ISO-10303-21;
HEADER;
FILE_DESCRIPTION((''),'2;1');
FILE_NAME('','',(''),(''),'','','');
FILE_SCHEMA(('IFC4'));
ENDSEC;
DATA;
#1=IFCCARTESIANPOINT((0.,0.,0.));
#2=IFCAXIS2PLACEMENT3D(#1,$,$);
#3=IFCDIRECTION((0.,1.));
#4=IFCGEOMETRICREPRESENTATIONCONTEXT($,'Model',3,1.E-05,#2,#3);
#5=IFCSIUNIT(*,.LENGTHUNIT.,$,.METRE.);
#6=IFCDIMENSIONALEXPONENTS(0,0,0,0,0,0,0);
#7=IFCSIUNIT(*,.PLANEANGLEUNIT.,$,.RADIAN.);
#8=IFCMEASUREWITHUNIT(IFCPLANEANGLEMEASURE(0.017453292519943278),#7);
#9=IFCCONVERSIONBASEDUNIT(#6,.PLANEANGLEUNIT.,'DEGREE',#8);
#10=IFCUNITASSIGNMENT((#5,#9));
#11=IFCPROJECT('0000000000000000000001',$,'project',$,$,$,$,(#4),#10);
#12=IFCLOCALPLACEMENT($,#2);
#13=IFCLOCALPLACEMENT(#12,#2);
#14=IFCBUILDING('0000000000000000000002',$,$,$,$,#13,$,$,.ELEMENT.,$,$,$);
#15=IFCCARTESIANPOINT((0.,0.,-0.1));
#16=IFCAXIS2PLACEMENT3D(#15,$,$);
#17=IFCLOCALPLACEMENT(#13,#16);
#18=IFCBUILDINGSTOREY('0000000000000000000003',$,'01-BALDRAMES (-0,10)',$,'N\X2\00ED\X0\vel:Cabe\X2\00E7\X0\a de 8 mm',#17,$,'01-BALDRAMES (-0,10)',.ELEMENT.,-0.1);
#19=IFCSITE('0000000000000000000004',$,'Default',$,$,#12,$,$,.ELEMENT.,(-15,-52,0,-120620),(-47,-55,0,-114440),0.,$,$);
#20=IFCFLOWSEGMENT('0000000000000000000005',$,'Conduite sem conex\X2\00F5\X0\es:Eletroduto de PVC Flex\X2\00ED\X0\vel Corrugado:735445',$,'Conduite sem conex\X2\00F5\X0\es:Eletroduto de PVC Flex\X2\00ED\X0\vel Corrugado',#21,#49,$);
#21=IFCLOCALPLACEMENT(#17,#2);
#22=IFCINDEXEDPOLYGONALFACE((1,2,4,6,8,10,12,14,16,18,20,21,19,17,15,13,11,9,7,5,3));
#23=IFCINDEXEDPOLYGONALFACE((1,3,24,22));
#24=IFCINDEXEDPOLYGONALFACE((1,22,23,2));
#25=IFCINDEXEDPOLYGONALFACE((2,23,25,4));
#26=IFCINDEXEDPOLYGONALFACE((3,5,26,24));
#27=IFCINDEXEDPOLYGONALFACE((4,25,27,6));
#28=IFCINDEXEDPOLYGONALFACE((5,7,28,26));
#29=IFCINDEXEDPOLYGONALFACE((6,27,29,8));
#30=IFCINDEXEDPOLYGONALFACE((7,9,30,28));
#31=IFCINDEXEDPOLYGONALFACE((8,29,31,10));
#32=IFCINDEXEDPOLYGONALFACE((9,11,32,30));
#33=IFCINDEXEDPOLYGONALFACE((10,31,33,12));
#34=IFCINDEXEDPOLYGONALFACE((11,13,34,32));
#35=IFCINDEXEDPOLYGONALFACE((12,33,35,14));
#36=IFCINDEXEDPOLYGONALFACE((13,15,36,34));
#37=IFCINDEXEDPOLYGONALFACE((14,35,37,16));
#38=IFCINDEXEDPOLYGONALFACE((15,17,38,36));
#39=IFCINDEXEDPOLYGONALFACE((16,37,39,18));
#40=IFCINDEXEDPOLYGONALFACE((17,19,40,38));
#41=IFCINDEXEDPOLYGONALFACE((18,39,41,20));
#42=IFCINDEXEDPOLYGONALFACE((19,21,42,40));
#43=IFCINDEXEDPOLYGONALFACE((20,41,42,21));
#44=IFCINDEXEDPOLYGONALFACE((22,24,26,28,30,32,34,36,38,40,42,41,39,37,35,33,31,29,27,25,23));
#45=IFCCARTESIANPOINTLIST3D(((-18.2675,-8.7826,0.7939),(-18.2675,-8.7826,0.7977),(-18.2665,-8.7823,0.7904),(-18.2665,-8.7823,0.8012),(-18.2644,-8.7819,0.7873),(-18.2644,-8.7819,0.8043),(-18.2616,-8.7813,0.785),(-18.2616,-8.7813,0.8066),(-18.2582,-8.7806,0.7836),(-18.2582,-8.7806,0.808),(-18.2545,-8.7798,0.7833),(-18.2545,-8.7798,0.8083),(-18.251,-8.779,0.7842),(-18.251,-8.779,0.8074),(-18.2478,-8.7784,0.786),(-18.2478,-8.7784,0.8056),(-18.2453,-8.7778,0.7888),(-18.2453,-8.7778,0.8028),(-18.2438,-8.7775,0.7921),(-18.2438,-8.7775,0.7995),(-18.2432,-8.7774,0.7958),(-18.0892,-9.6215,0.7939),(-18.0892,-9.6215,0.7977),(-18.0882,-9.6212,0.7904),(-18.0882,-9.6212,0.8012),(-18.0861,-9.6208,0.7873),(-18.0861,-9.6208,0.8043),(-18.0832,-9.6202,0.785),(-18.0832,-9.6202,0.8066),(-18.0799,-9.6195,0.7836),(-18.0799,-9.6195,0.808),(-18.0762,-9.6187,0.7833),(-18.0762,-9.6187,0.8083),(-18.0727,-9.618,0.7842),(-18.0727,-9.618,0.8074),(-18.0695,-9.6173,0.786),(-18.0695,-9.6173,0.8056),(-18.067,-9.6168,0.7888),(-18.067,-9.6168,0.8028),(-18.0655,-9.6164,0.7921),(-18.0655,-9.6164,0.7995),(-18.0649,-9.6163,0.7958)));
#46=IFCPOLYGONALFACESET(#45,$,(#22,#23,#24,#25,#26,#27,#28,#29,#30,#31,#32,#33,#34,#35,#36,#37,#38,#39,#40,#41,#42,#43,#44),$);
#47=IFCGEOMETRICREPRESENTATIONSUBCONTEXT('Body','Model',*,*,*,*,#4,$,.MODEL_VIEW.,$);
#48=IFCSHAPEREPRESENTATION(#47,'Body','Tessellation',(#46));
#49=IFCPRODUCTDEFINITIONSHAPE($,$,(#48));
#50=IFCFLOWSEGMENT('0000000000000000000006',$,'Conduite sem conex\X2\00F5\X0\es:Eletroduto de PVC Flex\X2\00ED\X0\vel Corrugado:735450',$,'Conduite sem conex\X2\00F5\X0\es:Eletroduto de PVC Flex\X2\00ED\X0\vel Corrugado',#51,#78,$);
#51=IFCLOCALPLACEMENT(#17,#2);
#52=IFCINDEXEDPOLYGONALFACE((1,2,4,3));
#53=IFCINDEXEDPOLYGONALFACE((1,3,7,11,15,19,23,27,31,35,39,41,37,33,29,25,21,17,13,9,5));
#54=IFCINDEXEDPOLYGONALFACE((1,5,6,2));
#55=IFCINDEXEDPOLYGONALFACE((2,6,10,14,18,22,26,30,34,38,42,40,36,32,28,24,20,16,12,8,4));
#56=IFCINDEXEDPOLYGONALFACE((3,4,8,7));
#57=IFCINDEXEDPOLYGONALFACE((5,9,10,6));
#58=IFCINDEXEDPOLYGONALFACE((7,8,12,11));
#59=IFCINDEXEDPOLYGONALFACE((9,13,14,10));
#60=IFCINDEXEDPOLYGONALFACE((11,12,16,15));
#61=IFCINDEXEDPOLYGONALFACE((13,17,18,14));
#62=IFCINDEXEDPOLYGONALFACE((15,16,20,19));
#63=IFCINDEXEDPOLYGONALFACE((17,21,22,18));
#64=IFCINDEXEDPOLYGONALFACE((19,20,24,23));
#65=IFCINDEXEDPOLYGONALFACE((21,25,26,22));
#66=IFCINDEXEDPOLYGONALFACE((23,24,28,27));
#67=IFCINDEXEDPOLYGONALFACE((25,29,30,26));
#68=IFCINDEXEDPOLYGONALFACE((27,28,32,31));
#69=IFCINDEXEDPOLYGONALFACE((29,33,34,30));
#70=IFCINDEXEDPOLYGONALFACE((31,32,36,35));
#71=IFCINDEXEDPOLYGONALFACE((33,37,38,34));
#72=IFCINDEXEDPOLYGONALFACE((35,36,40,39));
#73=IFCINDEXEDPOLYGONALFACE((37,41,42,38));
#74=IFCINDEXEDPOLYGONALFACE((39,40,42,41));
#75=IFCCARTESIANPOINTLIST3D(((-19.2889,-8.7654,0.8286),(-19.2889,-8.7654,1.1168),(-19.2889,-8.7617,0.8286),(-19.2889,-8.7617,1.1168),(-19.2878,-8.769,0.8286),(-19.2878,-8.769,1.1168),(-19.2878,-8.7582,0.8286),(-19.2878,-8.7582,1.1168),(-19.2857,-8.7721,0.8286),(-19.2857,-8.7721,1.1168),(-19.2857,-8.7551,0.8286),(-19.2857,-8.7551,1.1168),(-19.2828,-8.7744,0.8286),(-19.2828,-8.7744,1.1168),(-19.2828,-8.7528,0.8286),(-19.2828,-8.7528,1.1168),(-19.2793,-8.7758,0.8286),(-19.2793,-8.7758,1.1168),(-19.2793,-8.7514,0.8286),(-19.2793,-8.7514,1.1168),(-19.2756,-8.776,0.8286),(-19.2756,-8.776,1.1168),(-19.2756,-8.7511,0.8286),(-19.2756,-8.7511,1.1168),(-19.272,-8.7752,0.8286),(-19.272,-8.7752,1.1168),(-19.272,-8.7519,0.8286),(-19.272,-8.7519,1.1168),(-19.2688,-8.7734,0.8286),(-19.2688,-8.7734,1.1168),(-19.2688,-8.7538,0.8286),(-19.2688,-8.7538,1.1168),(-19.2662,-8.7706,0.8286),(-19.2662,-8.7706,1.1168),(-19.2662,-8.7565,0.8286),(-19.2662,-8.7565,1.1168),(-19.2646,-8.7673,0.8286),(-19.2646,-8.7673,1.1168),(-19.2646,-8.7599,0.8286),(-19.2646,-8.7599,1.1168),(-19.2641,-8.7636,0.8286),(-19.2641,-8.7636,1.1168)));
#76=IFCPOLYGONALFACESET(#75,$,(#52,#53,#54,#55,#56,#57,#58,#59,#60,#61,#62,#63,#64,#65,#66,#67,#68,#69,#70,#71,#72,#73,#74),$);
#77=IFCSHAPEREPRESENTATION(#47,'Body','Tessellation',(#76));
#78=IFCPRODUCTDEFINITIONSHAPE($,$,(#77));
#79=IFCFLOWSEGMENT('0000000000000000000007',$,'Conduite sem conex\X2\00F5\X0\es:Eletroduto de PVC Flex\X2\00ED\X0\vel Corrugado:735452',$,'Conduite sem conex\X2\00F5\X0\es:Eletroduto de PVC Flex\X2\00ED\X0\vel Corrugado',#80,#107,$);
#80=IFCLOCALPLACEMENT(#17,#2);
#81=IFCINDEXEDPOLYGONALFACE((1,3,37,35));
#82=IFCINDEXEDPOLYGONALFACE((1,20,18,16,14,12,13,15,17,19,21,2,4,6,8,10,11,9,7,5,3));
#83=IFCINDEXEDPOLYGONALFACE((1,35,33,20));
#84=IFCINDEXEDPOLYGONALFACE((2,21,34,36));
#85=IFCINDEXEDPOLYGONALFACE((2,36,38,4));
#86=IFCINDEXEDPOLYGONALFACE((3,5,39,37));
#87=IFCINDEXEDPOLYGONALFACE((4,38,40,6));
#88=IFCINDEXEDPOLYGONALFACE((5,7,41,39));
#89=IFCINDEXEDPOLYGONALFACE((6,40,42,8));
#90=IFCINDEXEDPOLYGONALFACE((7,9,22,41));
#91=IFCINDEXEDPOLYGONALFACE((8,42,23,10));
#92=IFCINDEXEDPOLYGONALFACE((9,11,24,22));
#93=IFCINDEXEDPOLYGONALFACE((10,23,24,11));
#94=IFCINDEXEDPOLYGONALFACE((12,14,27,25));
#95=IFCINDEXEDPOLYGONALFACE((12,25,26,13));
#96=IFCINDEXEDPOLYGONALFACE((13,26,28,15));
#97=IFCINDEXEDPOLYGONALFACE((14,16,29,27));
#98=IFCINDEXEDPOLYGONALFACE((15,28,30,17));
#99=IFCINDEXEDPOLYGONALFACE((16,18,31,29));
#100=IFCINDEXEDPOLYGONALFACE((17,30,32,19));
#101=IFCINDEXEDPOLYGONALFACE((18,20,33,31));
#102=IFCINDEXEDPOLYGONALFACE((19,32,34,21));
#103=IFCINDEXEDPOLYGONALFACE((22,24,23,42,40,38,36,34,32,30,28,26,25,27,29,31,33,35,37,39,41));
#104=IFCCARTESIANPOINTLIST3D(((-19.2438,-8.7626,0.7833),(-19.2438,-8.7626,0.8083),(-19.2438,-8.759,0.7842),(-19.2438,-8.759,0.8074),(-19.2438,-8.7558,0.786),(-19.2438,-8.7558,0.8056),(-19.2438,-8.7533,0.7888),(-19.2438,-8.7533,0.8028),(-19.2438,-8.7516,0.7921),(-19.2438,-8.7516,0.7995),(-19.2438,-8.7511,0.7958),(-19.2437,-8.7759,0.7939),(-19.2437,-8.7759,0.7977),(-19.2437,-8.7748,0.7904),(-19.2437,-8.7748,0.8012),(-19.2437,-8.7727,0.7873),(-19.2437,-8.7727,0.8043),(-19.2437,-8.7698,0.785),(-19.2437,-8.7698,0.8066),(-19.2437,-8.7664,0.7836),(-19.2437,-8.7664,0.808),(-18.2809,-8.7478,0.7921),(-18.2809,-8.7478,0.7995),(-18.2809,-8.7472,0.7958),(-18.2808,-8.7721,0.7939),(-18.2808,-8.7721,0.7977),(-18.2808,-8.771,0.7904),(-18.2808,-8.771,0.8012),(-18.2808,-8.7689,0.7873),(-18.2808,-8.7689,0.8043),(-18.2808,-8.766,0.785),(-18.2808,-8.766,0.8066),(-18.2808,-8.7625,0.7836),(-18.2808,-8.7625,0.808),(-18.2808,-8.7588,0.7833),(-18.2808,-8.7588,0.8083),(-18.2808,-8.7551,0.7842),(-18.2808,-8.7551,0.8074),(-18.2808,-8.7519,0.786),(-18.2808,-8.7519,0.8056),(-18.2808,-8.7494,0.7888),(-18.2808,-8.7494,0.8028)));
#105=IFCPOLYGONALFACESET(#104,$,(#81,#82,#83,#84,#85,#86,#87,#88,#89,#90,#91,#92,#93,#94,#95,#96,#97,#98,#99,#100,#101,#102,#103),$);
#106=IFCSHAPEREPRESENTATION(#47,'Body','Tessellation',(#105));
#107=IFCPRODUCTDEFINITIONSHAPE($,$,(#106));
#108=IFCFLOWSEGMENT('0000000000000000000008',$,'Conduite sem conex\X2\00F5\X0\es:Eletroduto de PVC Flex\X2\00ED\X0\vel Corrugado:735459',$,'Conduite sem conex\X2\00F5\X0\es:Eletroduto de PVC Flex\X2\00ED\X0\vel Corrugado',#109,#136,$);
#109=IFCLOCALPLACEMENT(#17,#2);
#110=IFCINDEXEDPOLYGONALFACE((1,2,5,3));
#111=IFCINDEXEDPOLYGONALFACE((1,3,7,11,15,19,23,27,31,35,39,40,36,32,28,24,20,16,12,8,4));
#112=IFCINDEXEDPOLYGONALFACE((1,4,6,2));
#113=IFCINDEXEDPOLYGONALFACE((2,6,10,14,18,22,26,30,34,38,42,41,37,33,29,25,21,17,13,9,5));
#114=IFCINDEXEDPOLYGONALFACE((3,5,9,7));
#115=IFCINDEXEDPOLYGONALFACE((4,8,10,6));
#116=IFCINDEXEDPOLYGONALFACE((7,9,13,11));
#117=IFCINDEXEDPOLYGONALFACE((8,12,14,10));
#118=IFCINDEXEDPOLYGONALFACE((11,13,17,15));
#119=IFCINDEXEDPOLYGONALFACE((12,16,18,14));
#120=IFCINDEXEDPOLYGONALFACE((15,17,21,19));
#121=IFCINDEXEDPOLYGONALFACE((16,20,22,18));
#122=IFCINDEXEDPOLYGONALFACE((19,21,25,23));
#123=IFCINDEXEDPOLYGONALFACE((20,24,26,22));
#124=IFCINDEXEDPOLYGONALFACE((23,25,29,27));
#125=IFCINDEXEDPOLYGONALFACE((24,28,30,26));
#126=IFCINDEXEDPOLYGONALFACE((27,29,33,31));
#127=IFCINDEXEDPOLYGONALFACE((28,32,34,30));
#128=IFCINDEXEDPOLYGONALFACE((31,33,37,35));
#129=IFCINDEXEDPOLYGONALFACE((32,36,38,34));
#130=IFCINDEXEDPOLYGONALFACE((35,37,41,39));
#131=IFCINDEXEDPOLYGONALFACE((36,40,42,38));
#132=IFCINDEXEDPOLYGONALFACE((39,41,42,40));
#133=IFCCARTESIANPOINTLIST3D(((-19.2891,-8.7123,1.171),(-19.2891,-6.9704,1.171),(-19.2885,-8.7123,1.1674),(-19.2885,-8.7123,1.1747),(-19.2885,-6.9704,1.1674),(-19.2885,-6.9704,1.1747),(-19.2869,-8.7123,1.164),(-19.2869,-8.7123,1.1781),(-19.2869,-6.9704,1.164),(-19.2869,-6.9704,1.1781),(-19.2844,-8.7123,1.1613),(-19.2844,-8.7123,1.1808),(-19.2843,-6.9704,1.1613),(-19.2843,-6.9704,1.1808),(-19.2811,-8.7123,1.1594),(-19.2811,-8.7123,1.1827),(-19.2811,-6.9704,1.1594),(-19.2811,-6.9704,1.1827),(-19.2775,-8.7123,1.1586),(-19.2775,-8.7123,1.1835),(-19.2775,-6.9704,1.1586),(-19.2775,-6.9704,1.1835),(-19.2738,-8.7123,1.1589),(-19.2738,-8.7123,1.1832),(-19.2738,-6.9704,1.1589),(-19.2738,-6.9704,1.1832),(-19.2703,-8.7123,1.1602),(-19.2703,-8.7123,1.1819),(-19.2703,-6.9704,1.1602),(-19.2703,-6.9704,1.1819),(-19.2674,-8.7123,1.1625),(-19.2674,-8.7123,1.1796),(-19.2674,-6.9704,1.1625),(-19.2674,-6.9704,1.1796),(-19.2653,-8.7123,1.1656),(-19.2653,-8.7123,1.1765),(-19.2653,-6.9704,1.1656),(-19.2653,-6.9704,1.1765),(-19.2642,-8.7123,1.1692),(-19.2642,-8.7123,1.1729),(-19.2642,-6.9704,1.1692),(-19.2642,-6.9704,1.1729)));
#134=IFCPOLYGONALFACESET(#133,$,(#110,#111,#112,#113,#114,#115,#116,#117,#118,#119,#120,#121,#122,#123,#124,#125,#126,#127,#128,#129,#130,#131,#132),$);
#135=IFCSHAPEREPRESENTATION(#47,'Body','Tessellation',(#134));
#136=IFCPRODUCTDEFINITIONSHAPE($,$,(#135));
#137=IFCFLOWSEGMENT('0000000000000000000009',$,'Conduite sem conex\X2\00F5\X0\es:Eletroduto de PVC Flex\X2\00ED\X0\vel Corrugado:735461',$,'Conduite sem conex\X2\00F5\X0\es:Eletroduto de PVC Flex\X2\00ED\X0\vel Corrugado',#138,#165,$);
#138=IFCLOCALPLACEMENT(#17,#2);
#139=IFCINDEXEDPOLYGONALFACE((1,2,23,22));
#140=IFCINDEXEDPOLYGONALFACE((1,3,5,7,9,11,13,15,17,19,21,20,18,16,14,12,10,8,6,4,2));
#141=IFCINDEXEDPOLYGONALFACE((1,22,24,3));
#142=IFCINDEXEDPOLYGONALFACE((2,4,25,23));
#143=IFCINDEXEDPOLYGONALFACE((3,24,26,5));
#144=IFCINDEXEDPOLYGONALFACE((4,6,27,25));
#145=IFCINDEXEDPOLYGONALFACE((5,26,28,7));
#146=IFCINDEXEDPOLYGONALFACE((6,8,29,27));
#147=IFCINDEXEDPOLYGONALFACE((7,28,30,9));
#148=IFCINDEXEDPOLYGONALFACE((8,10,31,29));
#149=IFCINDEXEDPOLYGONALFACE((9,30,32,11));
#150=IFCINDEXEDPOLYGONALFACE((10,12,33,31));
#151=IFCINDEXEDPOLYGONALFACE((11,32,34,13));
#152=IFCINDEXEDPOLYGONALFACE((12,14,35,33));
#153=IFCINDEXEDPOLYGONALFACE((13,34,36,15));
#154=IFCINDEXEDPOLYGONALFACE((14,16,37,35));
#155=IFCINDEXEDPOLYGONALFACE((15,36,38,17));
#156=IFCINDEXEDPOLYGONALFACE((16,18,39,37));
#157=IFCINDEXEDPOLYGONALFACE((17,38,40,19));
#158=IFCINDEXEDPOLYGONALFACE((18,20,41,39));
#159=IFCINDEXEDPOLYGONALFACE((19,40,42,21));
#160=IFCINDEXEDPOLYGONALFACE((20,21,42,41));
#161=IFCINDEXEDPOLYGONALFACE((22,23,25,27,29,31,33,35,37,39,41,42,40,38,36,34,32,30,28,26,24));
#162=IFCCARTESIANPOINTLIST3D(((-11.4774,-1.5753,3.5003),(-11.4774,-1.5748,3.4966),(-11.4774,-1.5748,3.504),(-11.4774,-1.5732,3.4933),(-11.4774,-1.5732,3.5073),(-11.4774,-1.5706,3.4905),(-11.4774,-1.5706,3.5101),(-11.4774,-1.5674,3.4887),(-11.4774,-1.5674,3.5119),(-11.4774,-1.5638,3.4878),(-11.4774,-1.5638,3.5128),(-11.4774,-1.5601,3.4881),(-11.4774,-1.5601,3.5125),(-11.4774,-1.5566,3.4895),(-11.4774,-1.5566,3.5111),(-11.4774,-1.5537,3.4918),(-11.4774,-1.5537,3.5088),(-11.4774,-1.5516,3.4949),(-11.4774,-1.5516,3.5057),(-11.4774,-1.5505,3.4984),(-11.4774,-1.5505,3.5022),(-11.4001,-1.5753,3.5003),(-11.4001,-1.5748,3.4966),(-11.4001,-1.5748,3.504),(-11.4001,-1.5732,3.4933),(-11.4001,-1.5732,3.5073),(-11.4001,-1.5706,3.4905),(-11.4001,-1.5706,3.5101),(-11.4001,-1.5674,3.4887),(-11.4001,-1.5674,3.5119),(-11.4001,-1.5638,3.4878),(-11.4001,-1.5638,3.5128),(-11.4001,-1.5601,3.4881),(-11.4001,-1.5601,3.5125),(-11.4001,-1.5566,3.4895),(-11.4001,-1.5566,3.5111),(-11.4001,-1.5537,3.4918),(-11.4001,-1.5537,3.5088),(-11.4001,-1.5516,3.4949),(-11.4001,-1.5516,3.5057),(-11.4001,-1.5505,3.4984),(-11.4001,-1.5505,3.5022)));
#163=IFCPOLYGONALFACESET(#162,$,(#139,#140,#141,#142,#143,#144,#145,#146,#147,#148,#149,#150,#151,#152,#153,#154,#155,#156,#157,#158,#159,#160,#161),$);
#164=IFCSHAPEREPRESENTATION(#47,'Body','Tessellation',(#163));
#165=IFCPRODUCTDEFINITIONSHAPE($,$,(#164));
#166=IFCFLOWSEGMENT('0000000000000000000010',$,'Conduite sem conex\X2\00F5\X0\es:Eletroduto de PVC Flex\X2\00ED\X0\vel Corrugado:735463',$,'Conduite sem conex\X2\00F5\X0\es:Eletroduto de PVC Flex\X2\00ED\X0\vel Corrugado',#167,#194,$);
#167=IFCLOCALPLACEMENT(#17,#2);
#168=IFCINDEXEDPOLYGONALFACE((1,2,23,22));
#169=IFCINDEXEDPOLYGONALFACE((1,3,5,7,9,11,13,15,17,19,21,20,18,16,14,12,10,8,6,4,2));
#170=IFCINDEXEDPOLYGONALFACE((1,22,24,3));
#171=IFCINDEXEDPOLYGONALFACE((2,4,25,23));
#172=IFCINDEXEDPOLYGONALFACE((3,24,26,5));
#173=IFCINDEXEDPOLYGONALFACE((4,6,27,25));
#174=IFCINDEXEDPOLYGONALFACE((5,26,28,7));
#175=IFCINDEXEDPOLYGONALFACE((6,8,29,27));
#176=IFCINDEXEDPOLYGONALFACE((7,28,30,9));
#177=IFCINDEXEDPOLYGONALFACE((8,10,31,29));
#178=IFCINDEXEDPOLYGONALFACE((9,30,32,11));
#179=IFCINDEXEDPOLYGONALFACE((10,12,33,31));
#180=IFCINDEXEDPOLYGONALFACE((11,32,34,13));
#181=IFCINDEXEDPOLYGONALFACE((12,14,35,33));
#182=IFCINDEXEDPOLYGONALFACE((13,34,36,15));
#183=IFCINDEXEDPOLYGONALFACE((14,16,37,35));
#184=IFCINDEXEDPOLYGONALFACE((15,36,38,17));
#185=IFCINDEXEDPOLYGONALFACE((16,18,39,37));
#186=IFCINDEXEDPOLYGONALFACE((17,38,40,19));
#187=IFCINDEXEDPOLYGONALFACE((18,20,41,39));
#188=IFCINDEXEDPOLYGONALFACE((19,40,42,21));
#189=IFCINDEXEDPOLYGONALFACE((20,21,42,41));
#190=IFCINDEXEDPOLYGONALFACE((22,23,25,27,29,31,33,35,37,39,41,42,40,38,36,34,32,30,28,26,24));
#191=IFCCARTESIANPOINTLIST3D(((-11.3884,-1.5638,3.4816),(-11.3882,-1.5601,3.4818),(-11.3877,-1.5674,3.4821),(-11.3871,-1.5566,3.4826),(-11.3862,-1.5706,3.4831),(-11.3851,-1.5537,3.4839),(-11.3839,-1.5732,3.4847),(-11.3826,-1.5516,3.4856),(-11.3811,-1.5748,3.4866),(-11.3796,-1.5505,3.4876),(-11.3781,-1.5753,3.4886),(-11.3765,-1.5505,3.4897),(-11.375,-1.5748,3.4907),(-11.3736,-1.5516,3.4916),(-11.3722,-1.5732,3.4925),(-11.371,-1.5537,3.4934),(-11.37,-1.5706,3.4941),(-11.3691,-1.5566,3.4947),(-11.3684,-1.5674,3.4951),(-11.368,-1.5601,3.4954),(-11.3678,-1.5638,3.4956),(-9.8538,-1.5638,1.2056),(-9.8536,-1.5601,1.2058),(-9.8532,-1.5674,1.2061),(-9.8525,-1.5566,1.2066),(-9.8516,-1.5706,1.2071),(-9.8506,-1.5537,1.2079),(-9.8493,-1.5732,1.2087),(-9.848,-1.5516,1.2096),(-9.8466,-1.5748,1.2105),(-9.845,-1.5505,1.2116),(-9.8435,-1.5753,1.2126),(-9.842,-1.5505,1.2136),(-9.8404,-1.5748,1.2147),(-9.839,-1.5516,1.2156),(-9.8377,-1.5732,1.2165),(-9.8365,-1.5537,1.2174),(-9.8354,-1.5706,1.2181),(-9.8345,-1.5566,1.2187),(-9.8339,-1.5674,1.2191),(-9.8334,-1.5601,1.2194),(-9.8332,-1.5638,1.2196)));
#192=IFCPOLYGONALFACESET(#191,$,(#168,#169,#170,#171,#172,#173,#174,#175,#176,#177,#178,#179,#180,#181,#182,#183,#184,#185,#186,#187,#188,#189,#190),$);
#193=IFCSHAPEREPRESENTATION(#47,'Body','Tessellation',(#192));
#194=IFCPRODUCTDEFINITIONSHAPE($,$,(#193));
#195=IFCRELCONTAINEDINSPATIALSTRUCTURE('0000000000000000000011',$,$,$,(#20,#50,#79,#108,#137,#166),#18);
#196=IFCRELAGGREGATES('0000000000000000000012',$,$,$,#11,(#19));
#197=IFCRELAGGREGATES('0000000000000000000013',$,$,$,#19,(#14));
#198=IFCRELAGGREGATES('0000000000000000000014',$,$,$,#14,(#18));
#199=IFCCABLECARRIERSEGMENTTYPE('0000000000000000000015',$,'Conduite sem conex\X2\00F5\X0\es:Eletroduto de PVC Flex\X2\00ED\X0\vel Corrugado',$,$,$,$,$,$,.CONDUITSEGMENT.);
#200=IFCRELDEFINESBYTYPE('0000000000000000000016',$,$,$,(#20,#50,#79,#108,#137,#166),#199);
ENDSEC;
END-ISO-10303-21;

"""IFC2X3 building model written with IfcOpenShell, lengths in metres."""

from ifc_helpers import new_model, entity, si_unit, converted_unit, direction, frame, frame_2d, origin, origin_2d_with_axis, place, context, subcontext, project, spatial, circle, extrude, type_object, element, save


model = new_model("IFC2X3")

# Units and contexts
model_context = context("Model", 3, precision=1e-05, world=origin(), true_north=direction((0.0, 1.0)))
body_context = subcontext(model_context, "Body", "Model", "MODEL_VIEW")
ifc_project = project(units=[si_unit("LENGTHUNIT", "METRE"), converted_unit("PLANEANGLEUNIT", "DEGREE", entity("IfcPlaneAngleMeasure", 0.017453292519943278), si_unit("PLANEANGLEUNIT", "RADIAN"), dimensions=[0, 0, 0, 0, 0, 0, 0])], contexts=[model_context])

# Site, building, storey
site_placement = place(None, origin())
site = spatial("IfcSite", under=ifc_project, at=site_placement, Name="Default", CompositionType="ELEMENT", RefLatitude=(-15, -52, 0, -120620), RefLongitude=(-47, -55, 0, -114440), RefElevation=0.0)
building_placement = place(site_placement, origin())
building = spatial("IfcBuilding", under=site, at=building_placement, CompositionType="ELEMENT")
storey_placement = place(building_placement, frame((0.0, 0.0, -0.1)))
storey = spatial("IfcBuildingStorey", under=building, at=storey_placement, Name="01-BALDRAMES (-0,10)", ObjectType="Nível:Cabeça de 8 mm", LongName="01-BALDRAMES (-0,10)", CompositionType="ELEMENT", Elevation=-0.1)

# Flow segments
cable_carrier_segment_type = type_object("IfcCableCarrierSegmentType", Name="Conduite sem conexões:Eletroduto de PVC Flexível Corrugado", PredefinedType="CONDUITSEGMENT")
flow_segment_1_placement = place(storey_placement, origin())
element("IfcFlowSegment", 1, at=flow_segment_1_placement, inside=storey, type_object=cable_carrier_segment_type, Name="Conduite sem conexões:Eletroduto de PVC Flexível Corrugado:735445", ObjectType="Conduite sem conexões:Eletroduto de PVC Flexível Corrugado", context=body_context, shape_type="SweptSolid", body=[
    extrude(circle(Radius=0.0125, at=frame_2d((0.0, 0.0), x_axis=(1.0, 0.0))), frame((-18.2555, -8.78, 0.7958), z_axis=(0.207912, -0.978148, 0.0), x_axis=(0.978148, 0.207912, 0.0)), (0.0, 0.0, 1.0), 0.8577),
])
flow_segment_2_placement = place(storey_placement, origin())
element("IfcFlowSegment", 2, at=flow_segment_2_placement, inside=storey, type_object=cable_carrier_segment_type, Name="Conduite sem conexões:Eletroduto de PVC Flexível Corrugado:735450", ObjectType="Conduite sem conexões:Eletroduto de PVC Flexível Corrugado", context=body_context, shape_type="SweptSolid", body=[
    extrude(circle(Radius=0.0125, at=frame_2d((0.0, 0.0), x_axis=(1.0, 0.0))), frame((-19.2766, -8.7636, 0.8286)), (0.0, 0.0, 1.0), 0.2882),
])
flow_segment_3_placement = place(storey_placement, origin())
element("IfcFlowSegment", 3, at=flow_segment_3_placement, inside=storey, type_object=cable_carrier_segment_type, Name="Conduite sem conexões:Eletroduto de PVC Flexível Corrugado:735452", ObjectType="Conduite sem conexões:Eletroduto de PVC Flexível Corrugado", context=body_context, shape_type="SweptSolid", body=[
    extrude(circle(Radius=0.0125, at=origin_2d_with_axis()), frame((-19.2438, -8.7636, 0.7958), z_axis=(0.999992, 0.004026, 0.0), x_axis=(-0.004026, 0.999992, 0.0)), (0.0, 0.0, 1.0), 0.963),
])
flow_segment_4_placement = place(storey_placement, origin())
element("IfcFlowSegment", 4, at=flow_segment_4_placement, inside=storey, type_object=cable_carrier_segment_type, Name="Conduite sem conexões:Eletroduto de PVC Flexível Corrugado:735459", ObjectType="Conduite sem conexões:Eletroduto de PVC Flexível Corrugado", context=body_context, shape_type="SweptSolid", body=[
    extrude(circle(Radius=0.0125, at=frame_2d((0.0, 0.0), x_axis=(1.0, 0.0))), frame((-19.2766, -8.7123, 1.171), z_axis=(0.000002, 1.0, 0.0), x_axis=(-1.0, 0.000002, 0.0)), (0.0, 0.0, 1.0), 1.7419),
])
flow_segment_5_placement = place(storey_placement, origin())
element("IfcFlowSegment", 5, at=flow_segment_5_placement, inside=storey, type_object=cable_carrier_segment_type, Name="Conduite sem conexões:Eletroduto de PVC Flexível Corrugado:735461", ObjectType="Conduite sem conexões:Eletroduto de PVC Flexível Corrugado", context=body_context, shape_type="SweptSolid", body=[
    extrude(circle(Radius=0.0125, at=frame_2d((0.0, 0.0), x_axis=(1.0, 0.0))), frame((-11.4774, -1.5628, 3.5003), z_axis=(1.0, 0.0, 0.0), x_axis=(0.0, -1.0, 0.0)), (0.0, 0.0, 1.0), 0.0774),
])
flow_segment_6_placement = place(storey_placement, origin())
element("IfcFlowSegment", 6, at=flow_segment_6_placement, inside=storey, type_object=cable_carrier_segment_type, Name="Conduite sem conexões:Eletroduto de PVC Flexível Corrugado:735463", ObjectType="Conduite sem conexões:Eletroduto de PVC Flexível Corrugado", context=body_context, shape_type="SweptSolid", body=[
    extrude(circle(Radius=0.0125, at=frame_2d((0.0, 0.0), x_axis=(1.0, 0.0))), frame((-9.8435, -1.5628, 1.2126), z_axis=(-0.559042, 0.0, 0.829139), x_axis=(0.0, -1.0, 0.0)), (0.0, 0.0, 1.0), 2.745),
])

save(model, "model.ifc")
